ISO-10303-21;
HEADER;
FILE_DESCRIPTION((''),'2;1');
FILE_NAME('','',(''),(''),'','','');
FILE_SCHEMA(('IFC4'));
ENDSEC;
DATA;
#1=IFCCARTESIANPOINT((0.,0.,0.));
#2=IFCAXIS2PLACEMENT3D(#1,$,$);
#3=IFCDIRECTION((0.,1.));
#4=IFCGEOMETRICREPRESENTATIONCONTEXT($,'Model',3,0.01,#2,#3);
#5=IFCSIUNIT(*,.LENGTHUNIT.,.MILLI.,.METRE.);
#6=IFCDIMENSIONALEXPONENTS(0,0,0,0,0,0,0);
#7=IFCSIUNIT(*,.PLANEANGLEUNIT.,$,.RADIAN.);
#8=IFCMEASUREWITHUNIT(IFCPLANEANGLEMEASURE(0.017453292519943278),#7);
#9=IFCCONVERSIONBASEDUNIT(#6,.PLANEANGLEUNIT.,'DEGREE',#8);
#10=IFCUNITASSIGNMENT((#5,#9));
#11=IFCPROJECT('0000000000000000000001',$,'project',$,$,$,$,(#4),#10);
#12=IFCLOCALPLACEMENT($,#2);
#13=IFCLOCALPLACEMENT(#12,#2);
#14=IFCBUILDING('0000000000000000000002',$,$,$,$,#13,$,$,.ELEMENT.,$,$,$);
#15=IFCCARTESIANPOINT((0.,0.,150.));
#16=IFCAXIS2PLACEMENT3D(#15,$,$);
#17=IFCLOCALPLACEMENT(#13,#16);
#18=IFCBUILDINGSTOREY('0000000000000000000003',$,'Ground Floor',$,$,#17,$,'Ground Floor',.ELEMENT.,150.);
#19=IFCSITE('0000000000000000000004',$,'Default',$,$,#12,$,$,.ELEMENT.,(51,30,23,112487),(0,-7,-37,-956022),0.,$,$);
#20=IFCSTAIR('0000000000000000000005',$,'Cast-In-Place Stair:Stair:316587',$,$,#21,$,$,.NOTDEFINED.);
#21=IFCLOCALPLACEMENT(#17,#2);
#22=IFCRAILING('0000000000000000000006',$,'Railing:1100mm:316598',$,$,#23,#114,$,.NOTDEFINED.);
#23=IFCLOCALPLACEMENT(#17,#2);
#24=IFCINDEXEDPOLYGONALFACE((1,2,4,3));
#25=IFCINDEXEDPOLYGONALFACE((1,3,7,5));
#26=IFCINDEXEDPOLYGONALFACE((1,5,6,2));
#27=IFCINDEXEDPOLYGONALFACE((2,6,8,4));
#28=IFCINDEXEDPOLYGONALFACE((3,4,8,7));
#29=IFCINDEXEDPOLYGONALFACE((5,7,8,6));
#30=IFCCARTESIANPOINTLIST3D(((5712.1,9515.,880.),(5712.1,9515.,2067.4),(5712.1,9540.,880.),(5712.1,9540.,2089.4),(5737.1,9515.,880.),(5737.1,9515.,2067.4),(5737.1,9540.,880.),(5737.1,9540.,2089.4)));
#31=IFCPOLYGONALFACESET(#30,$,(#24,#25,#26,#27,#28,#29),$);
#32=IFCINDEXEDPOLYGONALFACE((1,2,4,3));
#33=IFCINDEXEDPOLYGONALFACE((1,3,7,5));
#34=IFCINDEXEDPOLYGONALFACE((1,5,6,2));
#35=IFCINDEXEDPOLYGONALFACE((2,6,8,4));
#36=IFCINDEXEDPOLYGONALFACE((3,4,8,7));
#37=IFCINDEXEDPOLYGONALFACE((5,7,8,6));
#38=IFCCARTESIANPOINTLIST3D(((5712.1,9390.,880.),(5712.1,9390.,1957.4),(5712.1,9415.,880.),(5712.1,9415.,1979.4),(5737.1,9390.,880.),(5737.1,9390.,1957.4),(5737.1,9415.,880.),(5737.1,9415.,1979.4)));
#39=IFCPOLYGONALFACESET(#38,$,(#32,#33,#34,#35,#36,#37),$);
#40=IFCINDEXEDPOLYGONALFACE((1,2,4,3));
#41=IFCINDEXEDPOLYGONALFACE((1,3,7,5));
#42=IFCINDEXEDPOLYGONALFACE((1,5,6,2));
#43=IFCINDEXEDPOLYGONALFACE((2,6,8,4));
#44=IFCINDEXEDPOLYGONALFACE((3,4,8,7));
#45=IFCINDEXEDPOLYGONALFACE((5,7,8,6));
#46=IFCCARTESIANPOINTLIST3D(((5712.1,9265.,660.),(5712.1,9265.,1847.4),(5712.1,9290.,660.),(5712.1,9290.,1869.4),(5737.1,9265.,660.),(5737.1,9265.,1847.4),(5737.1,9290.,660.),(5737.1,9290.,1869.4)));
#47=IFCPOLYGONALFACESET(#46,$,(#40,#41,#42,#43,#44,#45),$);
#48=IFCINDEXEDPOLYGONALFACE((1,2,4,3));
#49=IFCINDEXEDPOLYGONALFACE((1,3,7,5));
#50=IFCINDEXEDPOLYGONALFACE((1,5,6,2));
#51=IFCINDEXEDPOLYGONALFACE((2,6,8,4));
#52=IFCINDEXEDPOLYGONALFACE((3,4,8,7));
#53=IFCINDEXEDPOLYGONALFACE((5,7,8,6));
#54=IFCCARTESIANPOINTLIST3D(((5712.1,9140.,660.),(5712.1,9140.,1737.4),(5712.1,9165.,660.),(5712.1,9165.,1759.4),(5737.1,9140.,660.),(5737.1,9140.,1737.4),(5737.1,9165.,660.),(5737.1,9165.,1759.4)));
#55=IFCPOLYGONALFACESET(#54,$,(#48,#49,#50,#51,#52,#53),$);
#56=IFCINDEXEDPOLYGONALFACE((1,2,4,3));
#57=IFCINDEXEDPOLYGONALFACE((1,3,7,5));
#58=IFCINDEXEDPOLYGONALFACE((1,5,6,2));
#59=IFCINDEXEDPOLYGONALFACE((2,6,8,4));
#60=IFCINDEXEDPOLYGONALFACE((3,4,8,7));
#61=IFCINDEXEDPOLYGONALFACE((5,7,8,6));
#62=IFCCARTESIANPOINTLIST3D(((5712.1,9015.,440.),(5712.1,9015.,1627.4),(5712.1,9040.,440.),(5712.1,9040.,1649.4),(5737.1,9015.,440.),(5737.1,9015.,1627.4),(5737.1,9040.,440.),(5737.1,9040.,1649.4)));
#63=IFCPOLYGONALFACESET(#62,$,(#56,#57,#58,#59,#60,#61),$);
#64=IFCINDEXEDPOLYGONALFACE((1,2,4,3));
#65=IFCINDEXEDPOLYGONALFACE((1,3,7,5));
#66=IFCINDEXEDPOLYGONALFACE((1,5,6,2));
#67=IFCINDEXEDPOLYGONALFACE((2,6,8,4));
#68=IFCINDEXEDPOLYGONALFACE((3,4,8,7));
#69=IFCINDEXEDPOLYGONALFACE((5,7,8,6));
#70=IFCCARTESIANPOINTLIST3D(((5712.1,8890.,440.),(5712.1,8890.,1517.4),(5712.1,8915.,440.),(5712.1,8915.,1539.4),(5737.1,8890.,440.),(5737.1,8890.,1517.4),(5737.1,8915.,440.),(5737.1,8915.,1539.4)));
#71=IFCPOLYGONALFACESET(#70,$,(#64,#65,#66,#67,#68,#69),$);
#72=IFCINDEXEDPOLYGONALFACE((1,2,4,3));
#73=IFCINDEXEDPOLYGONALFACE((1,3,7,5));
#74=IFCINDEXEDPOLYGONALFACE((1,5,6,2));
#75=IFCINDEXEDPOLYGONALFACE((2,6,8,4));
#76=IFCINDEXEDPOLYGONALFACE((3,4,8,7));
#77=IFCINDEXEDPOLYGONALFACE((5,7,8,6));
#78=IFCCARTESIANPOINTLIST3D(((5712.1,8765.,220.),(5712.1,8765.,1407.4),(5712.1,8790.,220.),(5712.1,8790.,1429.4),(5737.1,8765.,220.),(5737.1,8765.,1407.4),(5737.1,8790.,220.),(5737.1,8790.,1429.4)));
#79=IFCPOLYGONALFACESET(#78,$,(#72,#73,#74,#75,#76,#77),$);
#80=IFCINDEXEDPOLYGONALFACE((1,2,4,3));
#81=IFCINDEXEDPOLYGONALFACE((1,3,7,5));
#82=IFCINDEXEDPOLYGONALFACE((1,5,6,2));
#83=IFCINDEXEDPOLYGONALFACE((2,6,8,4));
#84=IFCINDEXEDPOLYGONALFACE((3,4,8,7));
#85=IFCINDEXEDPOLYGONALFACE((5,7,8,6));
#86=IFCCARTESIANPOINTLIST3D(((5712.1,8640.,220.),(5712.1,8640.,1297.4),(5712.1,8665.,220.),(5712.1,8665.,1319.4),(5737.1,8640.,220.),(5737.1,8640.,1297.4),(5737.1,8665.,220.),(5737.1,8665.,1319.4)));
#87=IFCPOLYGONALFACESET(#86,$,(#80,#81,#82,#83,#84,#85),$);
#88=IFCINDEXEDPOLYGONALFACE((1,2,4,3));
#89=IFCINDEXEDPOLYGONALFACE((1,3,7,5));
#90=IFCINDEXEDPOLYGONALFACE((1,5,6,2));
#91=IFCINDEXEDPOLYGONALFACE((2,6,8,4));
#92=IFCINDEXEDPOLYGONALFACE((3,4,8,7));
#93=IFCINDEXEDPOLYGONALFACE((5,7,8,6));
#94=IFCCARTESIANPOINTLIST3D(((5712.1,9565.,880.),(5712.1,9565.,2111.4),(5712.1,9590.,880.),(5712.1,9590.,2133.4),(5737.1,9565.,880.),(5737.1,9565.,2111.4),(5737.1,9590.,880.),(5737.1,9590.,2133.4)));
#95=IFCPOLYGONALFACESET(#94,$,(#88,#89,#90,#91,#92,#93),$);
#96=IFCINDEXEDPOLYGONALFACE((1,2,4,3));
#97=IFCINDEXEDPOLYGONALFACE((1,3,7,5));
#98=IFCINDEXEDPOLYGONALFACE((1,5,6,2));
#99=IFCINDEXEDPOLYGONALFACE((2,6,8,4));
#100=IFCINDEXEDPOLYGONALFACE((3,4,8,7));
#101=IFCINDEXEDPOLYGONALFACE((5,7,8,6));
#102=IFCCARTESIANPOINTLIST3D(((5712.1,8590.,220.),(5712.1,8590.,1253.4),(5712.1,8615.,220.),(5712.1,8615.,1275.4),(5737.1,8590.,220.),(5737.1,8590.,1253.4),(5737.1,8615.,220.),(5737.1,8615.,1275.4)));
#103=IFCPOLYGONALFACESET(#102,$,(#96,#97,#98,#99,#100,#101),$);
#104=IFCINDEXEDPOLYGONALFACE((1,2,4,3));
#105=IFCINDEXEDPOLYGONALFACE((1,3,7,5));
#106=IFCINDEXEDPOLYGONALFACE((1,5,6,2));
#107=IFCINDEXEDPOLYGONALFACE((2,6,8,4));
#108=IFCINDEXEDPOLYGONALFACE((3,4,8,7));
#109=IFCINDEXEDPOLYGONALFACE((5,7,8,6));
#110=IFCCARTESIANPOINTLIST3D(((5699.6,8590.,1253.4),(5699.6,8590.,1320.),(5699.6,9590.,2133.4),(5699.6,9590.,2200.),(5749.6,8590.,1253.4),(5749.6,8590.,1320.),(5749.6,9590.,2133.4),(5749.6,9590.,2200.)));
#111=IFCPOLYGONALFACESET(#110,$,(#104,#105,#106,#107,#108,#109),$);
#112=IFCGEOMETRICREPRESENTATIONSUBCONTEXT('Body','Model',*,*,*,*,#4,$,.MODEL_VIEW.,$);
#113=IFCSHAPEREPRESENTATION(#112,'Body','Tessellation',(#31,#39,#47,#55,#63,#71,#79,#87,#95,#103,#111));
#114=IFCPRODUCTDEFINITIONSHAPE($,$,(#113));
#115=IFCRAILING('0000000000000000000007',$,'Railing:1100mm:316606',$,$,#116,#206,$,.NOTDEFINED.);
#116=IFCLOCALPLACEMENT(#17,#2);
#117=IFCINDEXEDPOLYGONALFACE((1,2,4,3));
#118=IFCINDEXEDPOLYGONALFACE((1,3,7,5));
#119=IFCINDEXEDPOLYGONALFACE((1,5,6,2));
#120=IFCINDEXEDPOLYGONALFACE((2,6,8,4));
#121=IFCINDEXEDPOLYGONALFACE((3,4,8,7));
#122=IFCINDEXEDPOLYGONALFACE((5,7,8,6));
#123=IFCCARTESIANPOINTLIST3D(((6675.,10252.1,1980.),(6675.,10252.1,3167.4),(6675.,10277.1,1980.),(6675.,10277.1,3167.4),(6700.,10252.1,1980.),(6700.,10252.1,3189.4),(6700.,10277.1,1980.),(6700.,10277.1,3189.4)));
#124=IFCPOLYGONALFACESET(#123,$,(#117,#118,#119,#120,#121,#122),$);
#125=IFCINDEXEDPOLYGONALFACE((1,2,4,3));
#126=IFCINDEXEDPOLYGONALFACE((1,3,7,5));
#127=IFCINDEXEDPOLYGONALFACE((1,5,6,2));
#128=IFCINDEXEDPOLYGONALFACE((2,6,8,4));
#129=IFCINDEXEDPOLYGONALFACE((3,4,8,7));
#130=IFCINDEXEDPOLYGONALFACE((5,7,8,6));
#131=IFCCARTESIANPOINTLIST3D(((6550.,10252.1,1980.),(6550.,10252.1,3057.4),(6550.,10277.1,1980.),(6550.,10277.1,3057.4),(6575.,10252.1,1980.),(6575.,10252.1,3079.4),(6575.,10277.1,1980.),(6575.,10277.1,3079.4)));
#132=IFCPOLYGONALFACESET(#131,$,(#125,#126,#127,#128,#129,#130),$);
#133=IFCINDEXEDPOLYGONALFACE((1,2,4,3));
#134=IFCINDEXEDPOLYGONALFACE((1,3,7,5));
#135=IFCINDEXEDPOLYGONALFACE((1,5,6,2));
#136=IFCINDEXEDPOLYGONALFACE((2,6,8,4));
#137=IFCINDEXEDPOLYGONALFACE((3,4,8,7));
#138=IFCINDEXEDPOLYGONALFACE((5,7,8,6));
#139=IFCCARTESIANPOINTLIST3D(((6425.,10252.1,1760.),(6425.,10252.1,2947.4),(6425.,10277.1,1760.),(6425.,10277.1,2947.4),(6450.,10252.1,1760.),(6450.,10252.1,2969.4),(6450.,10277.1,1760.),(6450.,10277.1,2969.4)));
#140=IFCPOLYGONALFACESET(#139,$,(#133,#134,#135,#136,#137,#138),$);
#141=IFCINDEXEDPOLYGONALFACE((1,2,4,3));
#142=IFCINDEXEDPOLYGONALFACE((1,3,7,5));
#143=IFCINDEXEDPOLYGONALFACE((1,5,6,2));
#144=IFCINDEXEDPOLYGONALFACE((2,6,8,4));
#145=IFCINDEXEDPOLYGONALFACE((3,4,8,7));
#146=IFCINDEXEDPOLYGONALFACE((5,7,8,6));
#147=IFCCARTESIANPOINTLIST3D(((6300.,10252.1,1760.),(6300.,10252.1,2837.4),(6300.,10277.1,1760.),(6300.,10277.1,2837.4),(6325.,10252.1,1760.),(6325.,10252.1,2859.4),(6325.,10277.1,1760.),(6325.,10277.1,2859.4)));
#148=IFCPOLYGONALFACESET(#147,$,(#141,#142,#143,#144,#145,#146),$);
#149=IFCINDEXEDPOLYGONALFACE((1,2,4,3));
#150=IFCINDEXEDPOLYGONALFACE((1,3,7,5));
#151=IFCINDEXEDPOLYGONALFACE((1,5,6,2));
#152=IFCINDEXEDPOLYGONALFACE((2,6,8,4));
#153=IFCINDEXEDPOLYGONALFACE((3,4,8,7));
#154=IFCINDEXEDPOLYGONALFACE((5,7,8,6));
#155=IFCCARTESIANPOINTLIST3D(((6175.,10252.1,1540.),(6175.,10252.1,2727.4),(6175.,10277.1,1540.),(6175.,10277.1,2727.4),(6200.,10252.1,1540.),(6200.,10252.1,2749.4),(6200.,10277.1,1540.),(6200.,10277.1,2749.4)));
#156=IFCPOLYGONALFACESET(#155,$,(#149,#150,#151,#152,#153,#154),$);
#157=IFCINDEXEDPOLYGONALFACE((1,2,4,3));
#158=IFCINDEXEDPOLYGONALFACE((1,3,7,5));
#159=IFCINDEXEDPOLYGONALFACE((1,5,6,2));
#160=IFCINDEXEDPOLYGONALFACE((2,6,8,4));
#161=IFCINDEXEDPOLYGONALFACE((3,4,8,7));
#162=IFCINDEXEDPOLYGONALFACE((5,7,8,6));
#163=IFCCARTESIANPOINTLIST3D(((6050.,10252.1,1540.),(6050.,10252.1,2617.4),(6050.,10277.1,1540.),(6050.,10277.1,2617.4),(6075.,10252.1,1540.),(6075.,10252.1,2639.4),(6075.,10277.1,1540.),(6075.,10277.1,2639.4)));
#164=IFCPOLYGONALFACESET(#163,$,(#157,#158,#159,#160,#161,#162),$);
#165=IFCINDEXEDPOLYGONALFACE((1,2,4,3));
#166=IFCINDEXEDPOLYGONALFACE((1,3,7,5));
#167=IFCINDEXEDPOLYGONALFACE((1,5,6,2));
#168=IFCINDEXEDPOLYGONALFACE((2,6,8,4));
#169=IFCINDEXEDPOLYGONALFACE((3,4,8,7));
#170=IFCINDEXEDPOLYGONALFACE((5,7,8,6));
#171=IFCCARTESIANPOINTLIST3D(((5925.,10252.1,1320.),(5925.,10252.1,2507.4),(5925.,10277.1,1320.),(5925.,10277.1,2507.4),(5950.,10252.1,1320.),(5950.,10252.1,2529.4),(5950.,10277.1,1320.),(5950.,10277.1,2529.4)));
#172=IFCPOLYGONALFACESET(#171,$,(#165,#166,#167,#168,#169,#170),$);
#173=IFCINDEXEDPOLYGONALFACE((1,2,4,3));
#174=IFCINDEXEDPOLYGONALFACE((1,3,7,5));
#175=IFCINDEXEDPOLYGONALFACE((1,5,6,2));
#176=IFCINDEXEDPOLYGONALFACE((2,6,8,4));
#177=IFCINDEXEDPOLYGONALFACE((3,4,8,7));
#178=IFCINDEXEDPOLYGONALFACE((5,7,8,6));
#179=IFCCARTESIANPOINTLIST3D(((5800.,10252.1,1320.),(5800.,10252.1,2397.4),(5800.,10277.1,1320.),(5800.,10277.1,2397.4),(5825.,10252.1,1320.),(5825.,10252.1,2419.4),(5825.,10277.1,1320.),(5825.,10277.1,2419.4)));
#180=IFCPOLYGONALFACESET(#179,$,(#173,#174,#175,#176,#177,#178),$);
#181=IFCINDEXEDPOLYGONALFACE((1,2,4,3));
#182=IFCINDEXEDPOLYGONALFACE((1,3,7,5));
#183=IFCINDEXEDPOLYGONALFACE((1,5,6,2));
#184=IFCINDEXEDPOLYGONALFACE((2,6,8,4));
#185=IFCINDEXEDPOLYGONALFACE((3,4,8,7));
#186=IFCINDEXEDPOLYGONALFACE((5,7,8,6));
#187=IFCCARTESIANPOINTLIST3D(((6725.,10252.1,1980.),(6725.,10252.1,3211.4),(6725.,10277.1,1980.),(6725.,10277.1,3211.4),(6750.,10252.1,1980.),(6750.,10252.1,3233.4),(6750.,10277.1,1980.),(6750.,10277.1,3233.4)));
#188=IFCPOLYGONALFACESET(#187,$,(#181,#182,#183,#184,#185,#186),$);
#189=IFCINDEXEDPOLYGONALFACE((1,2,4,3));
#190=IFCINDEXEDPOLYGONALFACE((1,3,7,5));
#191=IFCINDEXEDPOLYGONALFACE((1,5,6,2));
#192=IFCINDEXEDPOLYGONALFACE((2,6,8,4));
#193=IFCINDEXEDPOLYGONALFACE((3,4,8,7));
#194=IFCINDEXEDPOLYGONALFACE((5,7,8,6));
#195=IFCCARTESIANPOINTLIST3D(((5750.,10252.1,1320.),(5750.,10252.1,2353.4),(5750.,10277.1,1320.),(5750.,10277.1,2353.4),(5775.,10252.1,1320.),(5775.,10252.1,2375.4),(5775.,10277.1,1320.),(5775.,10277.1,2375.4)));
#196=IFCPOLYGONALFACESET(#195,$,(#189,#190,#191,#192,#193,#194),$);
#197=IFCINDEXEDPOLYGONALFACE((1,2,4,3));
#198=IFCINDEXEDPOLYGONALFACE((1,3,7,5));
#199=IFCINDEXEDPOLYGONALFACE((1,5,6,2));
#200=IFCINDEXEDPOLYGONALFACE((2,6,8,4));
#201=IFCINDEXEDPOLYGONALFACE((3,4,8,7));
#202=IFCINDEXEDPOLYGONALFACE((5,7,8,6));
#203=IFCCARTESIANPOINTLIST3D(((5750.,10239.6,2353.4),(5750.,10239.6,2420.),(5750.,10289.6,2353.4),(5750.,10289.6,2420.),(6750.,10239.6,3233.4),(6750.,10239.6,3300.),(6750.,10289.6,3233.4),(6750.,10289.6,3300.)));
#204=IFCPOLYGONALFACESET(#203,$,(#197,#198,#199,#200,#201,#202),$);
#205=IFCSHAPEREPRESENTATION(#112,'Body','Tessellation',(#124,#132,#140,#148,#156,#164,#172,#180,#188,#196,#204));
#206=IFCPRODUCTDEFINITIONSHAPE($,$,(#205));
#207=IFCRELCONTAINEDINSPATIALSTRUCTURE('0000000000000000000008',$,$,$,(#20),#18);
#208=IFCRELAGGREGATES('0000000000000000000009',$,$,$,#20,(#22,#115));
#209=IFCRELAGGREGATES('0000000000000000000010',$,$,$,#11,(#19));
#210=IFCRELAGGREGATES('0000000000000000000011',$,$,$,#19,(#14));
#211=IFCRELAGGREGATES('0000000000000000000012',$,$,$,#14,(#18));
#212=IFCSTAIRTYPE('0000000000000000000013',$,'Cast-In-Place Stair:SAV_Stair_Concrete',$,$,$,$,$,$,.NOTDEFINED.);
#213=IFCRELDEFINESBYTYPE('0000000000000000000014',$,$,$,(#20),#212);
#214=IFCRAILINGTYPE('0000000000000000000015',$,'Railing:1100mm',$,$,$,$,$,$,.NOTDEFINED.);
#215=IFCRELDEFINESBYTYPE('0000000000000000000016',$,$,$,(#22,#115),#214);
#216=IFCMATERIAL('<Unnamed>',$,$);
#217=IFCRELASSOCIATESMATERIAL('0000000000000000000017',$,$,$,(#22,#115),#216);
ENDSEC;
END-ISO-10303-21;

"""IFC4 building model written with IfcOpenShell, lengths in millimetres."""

from ifc_helpers import new_model, entity, si_unit, converted_unit, direction, frame, origin, place, context, subcontext, project, spatial, polyline, outline, extrude, material, type_object, element, aggregate, save


model = new_model("IFC4")

# Units and contexts
model_context = context("Model", 3, precision=0.01, world=origin(), true_north=direction((0.0, 1.0)))
body_context = subcontext(model_context, "Body", "Model", "MODEL_VIEW")
ifc_project = project(units=[si_unit("LENGTHUNIT", "METRE", prefix="MILLI"), converted_unit("PLANEANGLEUNIT", "DEGREE", entity("IfcPlaneAngleMeasure", 0.017453292519943278), si_unit("PLANEANGLEUNIT", "RADIAN"), dimensions=[0, 0, 0, 0, 0, 0, 0])], contexts=[model_context])

# Site, building, storey
site_placement = place(None, origin())
site = spatial("IfcSite", under=ifc_project, at=site_placement, Name="Default", CompositionType="ELEMENT", RefLatitude=(51, 30, 23, 112487), RefLongitude=(0, -7, -37, -956022), RefElevation=0.0)
building_placement = place(site_placement, origin())
building = spatial("IfcBuilding", under=site, at=building_placement, CompositionType="ELEMENT")
storey_placement = place(building_placement, frame((0.0, 0.0, 150.0)))
storey = spatial("IfcBuildingStorey", under=building, at=storey_placement, Name="Ground Floor", LongName="Ground Floor", CompositionType="ELEMENT", Elevation=150.0)

# Shared definitions
ifc_material_1 = material(Name="<Unnamed>")

# Stair, railings
stair_type = type_object("IfcStairType", Name="Cast-In-Place Stair:SAV_Stair_Concrete", PredefinedType="NOTDEFINED")
stair_placement = place(storey_placement, origin())
stair = element("IfcStair", 1, at=stair_placement, inside=storey, type_object=stair_type, Name="Cast-In-Place Stair:Stair:316587", PredefinedType="NOTDEFINED")
railing_type_1 = type_object("IfcRailingType", Name="Railing:1100mm", PredefinedType="NOTDEFINED")
railing_1_placement = place(stair_placement, frame((5699.6, 8590.0, 220.0)))
railing_1 = element("IfcRailing", 2, at=railing_1_placement, type_object=railing_type_1, material=ifc_material_1, Name="Railing:1100mm:316598", PredefinedType="NOTDEFINED", context=body_context, shape_type="SweptSolid", body=[
    extrude(outline(polyline([(-12.5, -599.2), (12.5, -599.2), (12.5, 610.2), (-12.5, 588.2), (-12.5, -599.2)])), frame((12.5, 937.5, 1259.2), z_axis=(1.0, 0.0, 0.0), x_axis=(0.0, 1.0, 0.0)), (0.0, 0.0, 1.0), 25.0),
    extrude(outline(polyline([(-12.5, -544.2), (12.5, -544.2), (12.5, 555.2), (-12.5, 533.2), (-12.5, -544.2)])), frame((12.5, 812.5, 1204.2), z_axis=(1.0, 0.0, 0.0), x_axis=(0.0, 1.0, 0.0)), (0.0, 0.0, 1.0), 25.0),
    extrude(outline(polyline([(-12.5, -599.2), (12.5, -599.2), (12.5, 610.2), (-12.5, 588.2), (-12.5, -599.2)])), frame((12.5, 687.5, 1039.2), z_axis=(1.0, 0.0, 0.0), x_axis=(0.0, 1.0, 0.0)), (0.0, 0.0, 1.0), 25.0),
    extrude(outline(polyline([(-12.5, -544.2), (12.5, -544.2), (12.5, 555.2), (-12.5, 533.2), (-12.5, -544.2)])), frame((12.5, 562.5, 984.2), z_axis=(1.0, 0.0, 0.0), x_axis=(0.0, 1.0, 0.0)), (0.0, 0.0, 1.0), 25.0),
    extrude(outline(polyline([(-12.5, -599.2), (12.5, -599.2), (12.5, 610.2), (-12.5, 588.2), (-12.5, -599.2)])), frame((12.5, 437.5, 819.2), z_axis=(1.0, 0.0, 0.0), x_axis=(0.0, 1.0, 0.0)), (0.0, 0.0, 1.0), 25.0),
    extrude(outline(polyline([(-12.5, -544.2), (12.5, -544.2), (12.5, 555.2), (-12.5, 533.2), (-12.5, -544.2)])), frame((12.5, 312.5, 764.2), z_axis=(1.0, 0.0, 0.0), x_axis=(0.0, 1.0, 0.0)), (0.0, 0.0, 1.0), 25.0),
    extrude(outline(polyline([(-12.5, -599.2), (12.5, -599.2), (12.5, 610.2), (-12.5, 588.2), (-12.5, -599.2)])), frame((12.5, 187.5, 599.2), z_axis=(1.0, 0.0, 0.0), x_axis=(0.0, 1.0, 0.0)), (0.0, 0.0, 1.0), 25.0),
    extrude(outline(polyline([(-12.5, -544.2), (12.5, -544.2), (12.5, 555.2), (-12.5, 533.2), (-12.5, -544.2)])), frame((12.5, 62.5, 544.2), z_axis=(1.0, 0.0, 0.0), x_axis=(0.0, 1.0, 0.0)), (0.0, 0.0, 1.0), 25.0),
    extrude(outline(polyline([(-12.5, -621.2), (12.5, -621.2), (12.5, 632.2), (-12.5, 610.2), (-12.5, -621.2)])), frame((12.5, 987.5, 1281.2), z_axis=(1.0, 0.0, 0.0), x_axis=(0.0, 1.0, 0.0)), (0.0, 0.0, 1.0), 25.0),
    extrude(outline(polyline([(-12.5, -522.2), (12.5, -522.2), (12.5, 533.2), (-12.5, 511.2), (-12.5, -522.2)])), frame((12.5, 12.5, 522.2), z_axis=(1.0, 0.0, 0.0), x_axis=(0.0, 1.0, 0.0)), (0.0, 0.0, 1.0), 25.0),
    extrude(outline(polyline([(-688.0, -25.0), (644.0, -25.0), (688.0, 25.0), (-644.0, 25.0), (-688.0, -25.0)])), frame((0.0, 500.0, 1506.7), z_axis=(1.0, 0.0, 0.0), x_axis=(0.0, 0.750714, 0.660628)), (0.0, 0.0, 1.0), 50.0),
])
railing_2_placement = place(stair_placement, frame((5750.0, 10239.6, 1320.0)))
railing_2 = element("IfcRailing", 3, at=railing_2_placement, type_object=railing_type_1, material=ifc_material_1, Name="Railing:1100mm:316606", PredefinedType="NOTDEFINED", context=body_context, shape_type="SweptSolid", body=[
    extrude(outline(polyline([(-599.2, -12.5), (588.2, -12.5), (610.2, 12.5), (-599.2, 12.5), (-599.2, -12.5)])), frame((937.5, 12.5, 1259.2), z_axis=(0.0, 1.0, 0.0), x_axis=(0.0, 0.0, 1.0)), (0.0, 0.0, 1.0), 25.0),
    extrude(outline(polyline([(-544.2, -12.5), (533.2, -12.5), (555.2, 12.5), (-544.2, 12.5), (-544.2, -12.5)])), frame((812.5, 12.5, 1204.2), z_axis=(0.0, 1.0, 0.0), x_axis=(0.0, 0.0, 1.0)), (0.0, 0.0, 1.0), 25.0),
    extrude(outline(polyline([(-599.2, -12.5), (588.2, -12.5), (610.2, 12.5), (-599.2, 12.5), (-599.2, -12.5)])), frame((687.5, 12.5, 1039.2), z_axis=(0.0, 1.0, 0.0), x_axis=(0.0, 0.0, 1.0)), (0.0, 0.0, 1.0), 25.0),
    extrude(outline(polyline([(-544.2, -12.5), (533.2, -12.5), (555.2, 12.5), (-544.2, 12.5), (-544.2, -12.5)])), frame((562.5, 12.5, 984.2), z_axis=(0.0, 1.0, 0.0), x_axis=(0.0, 0.0, 1.0)), (0.0, 0.0, 1.0), 25.0),
    extrude(outline(polyline([(-599.2, -12.5), (588.2, -12.5), (610.2, 12.5), (-599.2, 12.5), (-599.2, -12.5)])), frame((437.5, 12.5, 819.2), z_axis=(0.0, 1.0, 0.0), x_axis=(0.0, 0.0, 1.0)), (0.0, 0.0, 1.0), 25.0),
    extrude(outline(polyline([(-544.2, -12.5), (533.2, -12.5), (555.2, 12.5), (-544.2, 12.5), (-544.2, -12.5)])), frame((312.5, 12.5, 764.2), z_axis=(0.0, 1.0, 0.0), x_axis=(0.0, 0.0, 1.0)), (0.0, 0.0, 1.0), 25.0),
    extrude(outline(polyline([(-599.2, -12.5), (588.2, -12.5), (610.2, 12.5), (-599.2, 12.5), (-599.2, -12.5)])), frame((187.5, 12.5, 599.2), z_axis=(0.0, 1.0, 0.0), x_axis=(0.0, 0.0, 1.0)), (0.0, 0.0, 1.0), 25.0),
    extrude(outline(polyline([(-544.2, -12.5), (533.2, -12.5), (555.2, 12.5), (-544.2, 12.5), (-544.2, -12.5)])), frame((62.5, 12.5, 544.2), z_axis=(0.0, 1.0, 0.0), x_axis=(0.0, 0.0, 1.0)), (0.0, 0.0, 1.0), 25.0),
    extrude(outline(polyline([(-621.2, -12.5), (610.2, -12.5), (632.2, 12.5), (-621.2, 12.5), (-621.2, -12.5)])), frame((987.5, 12.5, 1281.2), z_axis=(0.0, 1.0, 0.0), x_axis=(0.0, 0.0, 1.0)), (0.0, 0.0, 1.0), 25.0),
    extrude(outline(polyline([(-522.2, -12.5), (511.2, -12.5), (533.2, 12.5), (-522.2, 12.5), (-522.2, -12.5)])), frame((12.5, 12.5, 522.2), z_axis=(0.0, 1.0, 0.0), x_axis=(0.0, 0.0, 1.0)), (0.0, 0.0, 1.0), 25.0),
    extrude(outline(polyline([(-644.0, -25.0), (688.0, -25.0), (644.0, 25.0), (-688.0, 25.0), (-644.0, -25.0)])), frame((500.0, 0.0, 1506.7), z_axis=(0.0, 1.0, 0.0), x_axis=(0.750714, 0.0, 0.660628)), (0.0, 0.0, 1.0), 50.0),
])
aggregate(stair, [railing_1, railing_2])

save(model, "model.ifc")
